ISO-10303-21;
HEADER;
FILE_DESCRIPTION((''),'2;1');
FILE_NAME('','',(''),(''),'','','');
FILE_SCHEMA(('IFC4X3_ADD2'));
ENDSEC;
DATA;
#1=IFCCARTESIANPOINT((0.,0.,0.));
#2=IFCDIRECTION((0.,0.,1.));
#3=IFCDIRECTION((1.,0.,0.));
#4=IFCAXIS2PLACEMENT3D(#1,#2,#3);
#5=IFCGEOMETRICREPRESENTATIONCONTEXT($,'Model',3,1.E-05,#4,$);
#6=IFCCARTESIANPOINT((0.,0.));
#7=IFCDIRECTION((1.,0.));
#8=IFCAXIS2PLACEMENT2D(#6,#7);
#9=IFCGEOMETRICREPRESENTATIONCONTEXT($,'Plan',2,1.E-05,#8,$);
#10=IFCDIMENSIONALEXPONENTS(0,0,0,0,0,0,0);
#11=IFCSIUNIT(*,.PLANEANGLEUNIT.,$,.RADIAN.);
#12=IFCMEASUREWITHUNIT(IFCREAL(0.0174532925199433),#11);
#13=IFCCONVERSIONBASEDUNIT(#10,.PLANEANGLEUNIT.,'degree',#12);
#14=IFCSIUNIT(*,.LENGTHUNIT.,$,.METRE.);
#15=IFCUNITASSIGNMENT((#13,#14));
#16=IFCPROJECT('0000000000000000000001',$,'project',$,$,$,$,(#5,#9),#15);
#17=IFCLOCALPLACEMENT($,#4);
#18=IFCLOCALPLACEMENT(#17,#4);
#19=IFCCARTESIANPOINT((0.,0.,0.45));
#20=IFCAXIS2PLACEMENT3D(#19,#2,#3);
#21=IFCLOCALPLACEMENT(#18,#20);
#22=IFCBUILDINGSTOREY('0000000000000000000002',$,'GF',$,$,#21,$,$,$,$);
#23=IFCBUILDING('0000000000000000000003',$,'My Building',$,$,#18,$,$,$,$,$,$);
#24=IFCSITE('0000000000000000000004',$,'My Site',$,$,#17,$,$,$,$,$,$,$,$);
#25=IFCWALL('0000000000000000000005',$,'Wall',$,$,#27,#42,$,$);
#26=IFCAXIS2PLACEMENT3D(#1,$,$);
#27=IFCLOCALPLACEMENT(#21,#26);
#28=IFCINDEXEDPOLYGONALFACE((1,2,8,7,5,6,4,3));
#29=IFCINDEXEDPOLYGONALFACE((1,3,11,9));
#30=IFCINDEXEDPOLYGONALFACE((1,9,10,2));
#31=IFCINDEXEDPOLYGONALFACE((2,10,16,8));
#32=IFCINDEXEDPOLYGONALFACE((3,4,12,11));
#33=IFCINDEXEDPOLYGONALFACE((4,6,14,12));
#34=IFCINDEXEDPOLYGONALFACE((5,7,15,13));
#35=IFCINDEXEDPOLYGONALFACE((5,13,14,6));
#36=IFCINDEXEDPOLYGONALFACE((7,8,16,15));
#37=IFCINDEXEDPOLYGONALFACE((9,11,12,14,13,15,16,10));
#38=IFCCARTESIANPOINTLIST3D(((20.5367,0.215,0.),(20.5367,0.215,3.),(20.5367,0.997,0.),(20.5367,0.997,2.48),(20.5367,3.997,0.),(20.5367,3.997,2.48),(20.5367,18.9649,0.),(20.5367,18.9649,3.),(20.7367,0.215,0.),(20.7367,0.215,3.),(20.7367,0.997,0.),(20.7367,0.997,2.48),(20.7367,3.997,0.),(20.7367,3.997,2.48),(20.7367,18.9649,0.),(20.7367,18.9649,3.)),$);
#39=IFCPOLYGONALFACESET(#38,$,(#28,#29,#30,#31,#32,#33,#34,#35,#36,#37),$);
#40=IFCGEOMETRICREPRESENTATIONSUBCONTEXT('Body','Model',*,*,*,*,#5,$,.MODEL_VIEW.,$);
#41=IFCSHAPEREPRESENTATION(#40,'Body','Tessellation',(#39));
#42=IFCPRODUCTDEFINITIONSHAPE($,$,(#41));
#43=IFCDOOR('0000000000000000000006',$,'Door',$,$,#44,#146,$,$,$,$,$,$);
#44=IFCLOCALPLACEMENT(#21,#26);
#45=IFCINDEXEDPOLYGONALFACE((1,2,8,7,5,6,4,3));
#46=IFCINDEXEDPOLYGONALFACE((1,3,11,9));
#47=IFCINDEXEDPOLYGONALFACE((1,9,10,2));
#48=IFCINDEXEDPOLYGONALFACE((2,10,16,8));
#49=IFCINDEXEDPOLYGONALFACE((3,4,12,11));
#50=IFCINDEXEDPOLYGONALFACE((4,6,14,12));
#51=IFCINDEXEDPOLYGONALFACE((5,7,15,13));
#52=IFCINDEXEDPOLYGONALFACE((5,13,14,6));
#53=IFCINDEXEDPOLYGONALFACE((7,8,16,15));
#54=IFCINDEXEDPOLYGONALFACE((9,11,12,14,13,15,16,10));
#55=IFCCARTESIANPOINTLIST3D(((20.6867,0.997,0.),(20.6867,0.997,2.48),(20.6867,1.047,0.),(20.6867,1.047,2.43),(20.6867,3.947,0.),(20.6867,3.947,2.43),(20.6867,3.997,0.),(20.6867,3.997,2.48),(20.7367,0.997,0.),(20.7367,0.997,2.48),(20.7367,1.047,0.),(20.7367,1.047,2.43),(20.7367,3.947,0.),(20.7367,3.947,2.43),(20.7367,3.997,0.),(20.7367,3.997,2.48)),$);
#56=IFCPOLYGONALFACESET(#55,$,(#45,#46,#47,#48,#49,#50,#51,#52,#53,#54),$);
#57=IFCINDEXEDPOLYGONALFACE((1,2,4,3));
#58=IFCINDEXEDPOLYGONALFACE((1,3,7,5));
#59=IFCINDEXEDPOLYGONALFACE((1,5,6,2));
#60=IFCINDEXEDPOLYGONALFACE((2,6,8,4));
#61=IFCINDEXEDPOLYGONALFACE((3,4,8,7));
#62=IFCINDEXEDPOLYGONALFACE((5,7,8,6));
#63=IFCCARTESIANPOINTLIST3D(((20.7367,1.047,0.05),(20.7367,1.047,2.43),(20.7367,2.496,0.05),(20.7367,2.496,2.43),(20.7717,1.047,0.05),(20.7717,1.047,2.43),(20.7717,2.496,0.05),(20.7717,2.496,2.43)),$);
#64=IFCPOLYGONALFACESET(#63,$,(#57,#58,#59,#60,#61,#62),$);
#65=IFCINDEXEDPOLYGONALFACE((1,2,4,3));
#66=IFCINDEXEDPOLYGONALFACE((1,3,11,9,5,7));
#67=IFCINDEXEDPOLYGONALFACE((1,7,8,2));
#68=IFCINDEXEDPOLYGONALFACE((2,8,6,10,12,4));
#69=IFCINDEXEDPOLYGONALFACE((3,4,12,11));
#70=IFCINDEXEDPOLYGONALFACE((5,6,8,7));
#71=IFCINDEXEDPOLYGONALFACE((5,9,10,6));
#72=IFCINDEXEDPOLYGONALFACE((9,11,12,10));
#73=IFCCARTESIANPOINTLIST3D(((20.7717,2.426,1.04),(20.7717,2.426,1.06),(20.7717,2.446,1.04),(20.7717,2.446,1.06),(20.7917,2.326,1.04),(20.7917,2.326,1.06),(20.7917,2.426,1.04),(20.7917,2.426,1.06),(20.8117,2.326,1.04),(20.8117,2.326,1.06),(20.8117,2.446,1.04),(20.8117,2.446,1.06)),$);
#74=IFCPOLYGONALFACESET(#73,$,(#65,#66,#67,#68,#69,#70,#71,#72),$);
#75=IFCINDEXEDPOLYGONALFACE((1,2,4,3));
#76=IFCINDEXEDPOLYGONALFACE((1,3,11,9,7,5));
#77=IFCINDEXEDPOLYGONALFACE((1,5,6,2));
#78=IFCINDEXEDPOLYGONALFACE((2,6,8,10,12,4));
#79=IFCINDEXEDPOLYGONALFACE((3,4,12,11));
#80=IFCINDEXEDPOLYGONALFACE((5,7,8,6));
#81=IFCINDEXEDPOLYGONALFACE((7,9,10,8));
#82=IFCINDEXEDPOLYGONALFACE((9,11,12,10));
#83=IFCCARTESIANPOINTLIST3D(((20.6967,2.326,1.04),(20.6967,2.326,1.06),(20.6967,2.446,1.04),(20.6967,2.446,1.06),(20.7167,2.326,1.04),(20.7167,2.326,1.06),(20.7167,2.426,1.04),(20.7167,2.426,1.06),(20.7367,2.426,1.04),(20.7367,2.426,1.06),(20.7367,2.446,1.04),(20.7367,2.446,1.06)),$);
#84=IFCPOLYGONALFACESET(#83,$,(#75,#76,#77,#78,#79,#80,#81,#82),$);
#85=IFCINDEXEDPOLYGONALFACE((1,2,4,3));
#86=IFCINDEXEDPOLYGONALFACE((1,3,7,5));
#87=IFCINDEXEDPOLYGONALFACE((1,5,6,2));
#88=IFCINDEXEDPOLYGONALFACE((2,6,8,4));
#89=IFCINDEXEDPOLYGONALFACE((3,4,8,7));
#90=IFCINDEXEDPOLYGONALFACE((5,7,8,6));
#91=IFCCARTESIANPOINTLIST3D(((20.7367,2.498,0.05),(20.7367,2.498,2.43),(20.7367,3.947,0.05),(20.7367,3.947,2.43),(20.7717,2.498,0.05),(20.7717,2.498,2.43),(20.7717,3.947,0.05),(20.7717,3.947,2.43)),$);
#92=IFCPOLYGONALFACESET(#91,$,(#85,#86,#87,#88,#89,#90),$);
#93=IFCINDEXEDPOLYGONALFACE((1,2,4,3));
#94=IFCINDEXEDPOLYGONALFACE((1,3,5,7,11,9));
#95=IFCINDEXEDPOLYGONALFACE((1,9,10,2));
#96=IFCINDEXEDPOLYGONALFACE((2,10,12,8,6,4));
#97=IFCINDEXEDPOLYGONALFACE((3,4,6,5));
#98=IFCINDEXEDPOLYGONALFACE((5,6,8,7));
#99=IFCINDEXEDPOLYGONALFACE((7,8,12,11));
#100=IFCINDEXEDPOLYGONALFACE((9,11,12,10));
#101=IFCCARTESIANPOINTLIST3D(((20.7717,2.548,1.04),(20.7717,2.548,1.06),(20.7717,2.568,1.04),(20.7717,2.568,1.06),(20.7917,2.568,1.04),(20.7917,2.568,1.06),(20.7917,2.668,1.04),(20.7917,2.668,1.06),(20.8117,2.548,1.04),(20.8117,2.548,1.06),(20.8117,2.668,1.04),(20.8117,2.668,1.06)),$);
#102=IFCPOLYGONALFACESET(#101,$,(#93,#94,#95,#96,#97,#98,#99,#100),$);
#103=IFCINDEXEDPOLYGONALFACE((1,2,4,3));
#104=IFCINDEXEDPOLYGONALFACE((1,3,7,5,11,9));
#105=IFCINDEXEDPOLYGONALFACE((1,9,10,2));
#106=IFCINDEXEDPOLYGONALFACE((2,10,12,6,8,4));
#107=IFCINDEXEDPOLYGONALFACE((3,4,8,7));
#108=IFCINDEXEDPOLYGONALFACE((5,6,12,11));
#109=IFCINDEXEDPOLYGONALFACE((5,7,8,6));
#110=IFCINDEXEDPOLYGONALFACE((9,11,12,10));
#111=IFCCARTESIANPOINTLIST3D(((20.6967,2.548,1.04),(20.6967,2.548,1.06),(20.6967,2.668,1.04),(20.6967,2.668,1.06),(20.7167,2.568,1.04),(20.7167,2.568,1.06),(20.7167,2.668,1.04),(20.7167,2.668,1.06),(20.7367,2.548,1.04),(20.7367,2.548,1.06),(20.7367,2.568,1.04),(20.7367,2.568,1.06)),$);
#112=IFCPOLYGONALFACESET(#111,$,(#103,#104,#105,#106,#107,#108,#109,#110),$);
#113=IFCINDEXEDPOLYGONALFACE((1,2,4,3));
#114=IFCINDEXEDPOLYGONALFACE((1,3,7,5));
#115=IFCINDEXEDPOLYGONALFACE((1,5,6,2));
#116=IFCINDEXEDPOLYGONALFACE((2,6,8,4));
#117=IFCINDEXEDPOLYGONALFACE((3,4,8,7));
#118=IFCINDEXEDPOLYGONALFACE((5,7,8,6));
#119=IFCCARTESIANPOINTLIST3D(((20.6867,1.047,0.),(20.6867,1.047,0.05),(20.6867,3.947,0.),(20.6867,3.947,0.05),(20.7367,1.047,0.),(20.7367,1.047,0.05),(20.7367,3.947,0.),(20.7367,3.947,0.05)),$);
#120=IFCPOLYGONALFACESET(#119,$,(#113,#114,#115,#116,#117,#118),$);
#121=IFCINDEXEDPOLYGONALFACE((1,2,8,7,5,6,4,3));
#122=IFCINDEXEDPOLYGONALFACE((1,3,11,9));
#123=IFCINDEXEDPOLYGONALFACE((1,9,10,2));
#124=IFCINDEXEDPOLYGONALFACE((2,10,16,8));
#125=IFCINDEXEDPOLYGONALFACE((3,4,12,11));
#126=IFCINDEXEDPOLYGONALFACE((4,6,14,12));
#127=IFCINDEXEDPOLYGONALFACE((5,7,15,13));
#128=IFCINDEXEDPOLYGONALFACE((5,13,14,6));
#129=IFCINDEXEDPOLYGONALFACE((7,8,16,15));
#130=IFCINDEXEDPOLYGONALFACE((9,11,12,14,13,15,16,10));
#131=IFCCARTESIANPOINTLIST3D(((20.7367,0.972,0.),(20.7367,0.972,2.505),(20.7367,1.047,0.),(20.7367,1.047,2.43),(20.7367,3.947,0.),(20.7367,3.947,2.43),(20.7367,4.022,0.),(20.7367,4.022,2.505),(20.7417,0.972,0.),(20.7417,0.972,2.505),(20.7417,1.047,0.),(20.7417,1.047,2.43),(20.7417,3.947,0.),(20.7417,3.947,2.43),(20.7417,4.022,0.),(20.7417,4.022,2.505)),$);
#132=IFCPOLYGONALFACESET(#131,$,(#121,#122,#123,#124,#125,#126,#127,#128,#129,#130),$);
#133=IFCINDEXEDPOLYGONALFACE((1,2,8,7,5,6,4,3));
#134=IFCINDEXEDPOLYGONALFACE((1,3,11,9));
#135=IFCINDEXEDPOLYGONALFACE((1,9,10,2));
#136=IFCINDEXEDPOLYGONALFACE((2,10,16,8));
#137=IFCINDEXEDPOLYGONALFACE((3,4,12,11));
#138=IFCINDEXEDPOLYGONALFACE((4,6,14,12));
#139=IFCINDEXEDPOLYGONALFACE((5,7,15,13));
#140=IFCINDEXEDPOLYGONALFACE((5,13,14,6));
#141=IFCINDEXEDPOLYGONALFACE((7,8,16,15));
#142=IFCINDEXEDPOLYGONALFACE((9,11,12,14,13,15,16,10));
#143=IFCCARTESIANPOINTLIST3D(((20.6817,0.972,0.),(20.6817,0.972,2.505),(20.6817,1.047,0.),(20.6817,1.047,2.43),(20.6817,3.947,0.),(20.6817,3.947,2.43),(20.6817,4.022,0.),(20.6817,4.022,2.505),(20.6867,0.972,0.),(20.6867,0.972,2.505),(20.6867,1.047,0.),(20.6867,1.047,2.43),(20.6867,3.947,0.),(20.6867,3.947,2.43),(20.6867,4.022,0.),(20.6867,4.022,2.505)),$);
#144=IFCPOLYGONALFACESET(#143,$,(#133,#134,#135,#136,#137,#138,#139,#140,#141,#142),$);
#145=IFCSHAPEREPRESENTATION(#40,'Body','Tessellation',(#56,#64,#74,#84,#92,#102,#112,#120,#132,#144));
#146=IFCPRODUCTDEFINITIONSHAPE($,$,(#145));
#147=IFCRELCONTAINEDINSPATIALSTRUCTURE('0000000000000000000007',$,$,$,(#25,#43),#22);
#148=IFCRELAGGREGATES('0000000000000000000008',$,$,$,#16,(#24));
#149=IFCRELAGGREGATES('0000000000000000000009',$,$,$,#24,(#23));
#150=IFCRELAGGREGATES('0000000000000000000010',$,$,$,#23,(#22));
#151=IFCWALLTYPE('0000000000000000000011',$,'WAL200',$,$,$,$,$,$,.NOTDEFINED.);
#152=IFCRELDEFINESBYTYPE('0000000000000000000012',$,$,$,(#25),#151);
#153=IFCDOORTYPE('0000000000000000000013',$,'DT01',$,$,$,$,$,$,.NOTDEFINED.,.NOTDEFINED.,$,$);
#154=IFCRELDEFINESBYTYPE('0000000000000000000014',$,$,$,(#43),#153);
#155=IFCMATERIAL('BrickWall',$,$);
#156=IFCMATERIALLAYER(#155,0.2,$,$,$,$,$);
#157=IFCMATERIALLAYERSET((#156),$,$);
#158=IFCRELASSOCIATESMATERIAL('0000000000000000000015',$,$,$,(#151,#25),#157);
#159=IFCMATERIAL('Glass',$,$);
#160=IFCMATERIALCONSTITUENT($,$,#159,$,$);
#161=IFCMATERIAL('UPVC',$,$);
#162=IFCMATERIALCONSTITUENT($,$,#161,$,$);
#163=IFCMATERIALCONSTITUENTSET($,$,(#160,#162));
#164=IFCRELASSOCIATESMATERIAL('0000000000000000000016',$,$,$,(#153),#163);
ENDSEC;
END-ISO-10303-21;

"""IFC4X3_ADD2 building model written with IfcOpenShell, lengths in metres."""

from ifc_helpers import new_model, entity, si_unit, converted_unit, frame, origin_with_axes, origin_2d_with_axis, place, context, subcontext, project, spatial, line, indexed_curve, outline, extrude, shape, source, transform, mapped, material, layer, layer_set, layer_usage, constituent, constituent_set, type_object, type_shapes, element, fill, save


model = new_model("IFC4X3_ADD2")

# Units and contexts
model_context = context("Model", 3, precision=1e-05, world=origin_with_axes())
plan_context = context("Plan", 2, precision=1e-05, world=origin_2d_with_axis())
body_context_1 = subcontext(model_context, "Body", "Model", "MODEL_VIEW")
body_context_2 = subcontext(plan_context, "Body", "Plan", "PLAN_VIEW")
ifc_project = project(units=[converted_unit("PLANEANGLEUNIT", "degree", entity("IfcReal", 0.0174532925199433), si_unit("PLANEANGLEUNIT", "RADIAN"), dimensions=[0, 0, 0, 0, 0, 0, 0]), si_unit("LENGTHUNIT", "METRE")], contexts=[model_context, plan_context])

# Site, building, storey
site_placement = place(None, origin_with_axes())
site = spatial("IfcSite", under=ifc_project, at=site_placement, Name="My Site")
building_placement = place(site_placement, origin_with_axes())
building = spatial("IfcBuilding", under=site, at=building_placement, Name="My Building")
storey_placement = place(building_placement, frame((0.0, 0.0, 0.45), z_axis=(0.0, 0.0, 1.0), x_axis=(1.0, 0.0, 0.0)))
storey = spatial("IfcBuildingStorey", under=building, at=storey_placement, Name="GF")

# Shared definitions
ifc_material_1 = material(Name="BrickWall")
ifc_layer_1 = layer(ifc_material_1, 0.2)
ifc_layer_set_1 = layer_set([ifc_layer_1])
wall_type_1 = type_object("IfcWallType", Name="WAL200", PredefinedType="NOTDEFINED", material=ifc_layer_set_1)
shared_shape_1 = source(origin_with_axes(), body_context_1, "Body", "SweptSolid", [
    extrude(outline(indexed_curve([(0.0, 0.0), (3.0, 0.0), (3.0, 2.48), (0.0, 2.48)], segments=[line(1, 2, 3, 4, 1)])), frame((0.0, -0.6, 0.0), z_axis=(0.0, -1.0, 0.0), x_axis=(1.0, 0.0, 0.0)), (0.0, 0.0, -1.0), 1.2),
])
ifc_material_2 = material(Name="Glass")
ifc_constituent_1 = constituent(ifc_material_2)
ifc_material_3 = material(Name="UPVC")
ifc_constituent_2 = constituent(ifc_material_3)
ifc_constituent_set = constituent_set(constituents=[ifc_constituent_1, ifc_constituent_2])
door_type_1 = type_object("IfcDoorType", Name="DT01", OperationType="NOTDEFINED", PredefinedType="NOTDEFINED", material=ifc_constituent_set)
shared_shape_2 = source(origin_with_axes(), body_context_1, "Body", "SweptSolid", [
    extrude(outline(indexed_curve([(3.0, 0.0), (3.0, 2.48), (0.0, 2.48), (0.0, 0.0), (0.05, 0.0), (0.05, 2.43), (2.95, 2.43), (2.95, 0.0)], segments=[line(5, 4), line(4, 3), line(3, 2), line(2, 1), line(1, 8), line(8, 7), line(7, 6), line(6, 5)], self_intersect=False)), frame((0.0, 0.0, 0.0), z_axis=(0.0, -1.0, 0.0), x_axis=(1.0, 0.0, 0.0)), (0.0, 0.0, -1.0), 0.05),
    extrude(outline(indexed_curve([(0.0, 0.0), (1.449, 0.0), (1.449, 0.035), (0.0, 0.035)], segments=[line(1, 2, 3, 4, 1)])), frame((0.05, -0.035, 0.05), z_axis=(0.0, 0.0, 1.0), x_axis=(1.0, 0.0, 0.0)), (0.0, 0.0, 1.0), 2.38),
    extrude(outline(indexed_curve([(0.0, 0.0), (0.0, -0.04), (-0.12, -0.04), (-0.12, -0.02), (-0.02, -0.02), (-0.02, 0.0)], segments=[line(1, 2, 3, 4, 5, 6, 1)])), frame((1.449, -0.035, 1.04), z_axis=(0.0, 0.0, 1.0), x_axis=(1.0, 0.0, 0.0)), (0.0, 0.0, 1.0), 0.02),
    extrude(outline(indexed_curve([(0.0, 0.0), (0.0, 0.04), (-0.12, 0.04), (-0.12, 0.02), (-0.02, 0.02), (-0.02, 0.0)], segments=[line(1, 2, 3, 4, 5, 6, 1)])), frame((1.449, 0.0, 1.04), z_axis=(0.0, 0.0, 1.0), x_axis=(1.0, 0.0, 0.0)), (0.0, 0.0, 1.0), 0.02),
    extrude(outline(indexed_curve([(0.0, 0.0), (-1.449, 0.0), (-1.449, 0.035), (0.0, 0.035)], segments=[line(1, 2, 3, 4, 1)])), frame((2.95, -0.035, 0.05), z_axis=(0.0, 0.0, 1.0), x_axis=(1.0, 0.0, 0.0)), (0.0, 0.0, 1.0), 2.38),
    extrude(outline(indexed_curve([(0.0, 0.0), (0.0, -0.04), (0.12, -0.04), (0.12, -0.02), (0.02, -0.02), (0.02, 0.0)], segments=[line(1, 2, 3, 4, 5, 6, 1)])), frame((1.551, -0.035, 1.04), z_axis=(0.0, 0.0, 1.0), x_axis=(1.0, 0.0, 0.0)), (0.0, 0.0, 1.0), 0.02),
    extrude(outline(indexed_curve([(0.0, 0.0), (0.0, 0.04), (0.12, 0.04), (0.12, 0.02), (0.02, 0.02), (0.02, 0.0)], segments=[line(1, 2, 3, 4, 5, 6, 1)])), frame((1.551, 0.0, 1.04), z_axis=(0.0, 0.0, 1.0), x_axis=(1.0, 0.0, 0.0)), (0.0, 0.0, 1.0), 0.02),
    extrude(outline(indexed_curve([(0.0, 0.0), (2.9, 0.0), (2.9, 0.05), (0.0, 0.05)], segments=[line(1, 2, 3, 4, 1)])), frame((0.05, 0.0, 0.0), z_axis=(0.0, 0.0, 1.0), x_axis=(1.0, 0.0, 0.0)), (0.0, 0.0, 1.0), 0.05),
    extrude(outline(indexed_curve([(0.0, 0.0), (0.0, 2.505), (3.05, 2.505), (3.05, 0.0), (2.975, 0.0), (2.975, 2.43), (0.075, 2.43), (0.075, 0.0)], segments=[line(1, 2, 3, 4, 5, 6, 7, 8, 1)])), frame((-0.025, -0.005, 0.0), z_axis=(0.0, -1.0, 0.0), x_axis=(1.0, 0.0, 0.0)), (0.0, 0.0, -1.0), 0.005),
    extrude(outline(indexed_curve([(0.0, 0.0), (0.0, 2.505), (3.05, 2.505), (3.05, 0.0), (2.975, 0.0), (2.975, 2.43), (0.075, 2.43), (0.075, 0.0)], segments=[line(1, 2, 3, 4, 5, 6, 7, 8, 1)])), frame((-0.025, 0.05, 0.0), z_axis=(0.0, -1.0, 0.0), x_axis=(1.0, 0.0, 0.0)), (0.0, 0.0, -1.0), 0.005),
])
shared_shape_3 = source(origin_with_axes(), body_context_2, "Body", "Curve2D", [
    entity("IfcIndexedPolyCurve", entity("IfcCartesianPointList2D", [[0.0, 0.0], [0.05, 0.0], [0.05, 0.05], [0.0, 0.05]]), [entity("IfcLineIndex", [1, 2, 3, 4, 1])]),
    entity("IfcIndexedPolyCurve", entity("IfcCartesianPointList2D", [[3.0, 0.0], [2.95, 0.0], [2.95, 0.05], [3.0, 0.05]]), [entity("IfcLineIndex", [1, 2, 3, 4, 1])]),
    entity("IfcIndexedPolyCurve", entity("IfcCartesianPointList2D", [[-0.675, -0.035], [0.775, -0.035], [0.775, 0.0], [-0.675, 0.0]]), [entity("IfcLineIndex", [1, 2, 3, 4, 1])]),
    entity("IfcIndexedPolyCurve", entity("IfcCartesianPointList2D", [[3.675, -0.035], [2.225, -0.035], [2.225, 0.0], [3.675, 0.0]]), [entity("IfcLineIndex", [1, 2, 3, 4, 1])]),
])
type_shapes(door_type_1, [shared_shape_2, shared_shape_3])

# Wall, opening, door
ifc_layer_usage_1 = layer_usage(ifc_layer_set_1, "AXIS2", "POSITIVE", 0.0)
wall_1_placement = place(storey_placement, frame((20.7367, 0.215, 0.0), z_axis=(0.0, 0.0, 1.0), x_axis=(0.0, 1.0, 0.0)))
wall_1 = element("IfcWall", 1, at=wall_1_placement, inside=storey, type_object=wall_type_1, material=ifc_layer_usage_1, Name="Wall", context=body_context_1, shape_type="SweptSolid", body=[
    extrude(outline(indexed_curve([(0.0, 0.0), (0.0, 0.2), (18.7499, 0.2), (18.7499, 0.0), (0.0, 0.0)], self_intersect=False)), origin_with_axes(), (0.0, 0.0, 1.0), 3.0),
])
opening_1_placement = place(wall_1_placement, frame((0.782, 0.0, 0.0), z_axis=(0.0, 0.0, 1.0), x_axis=(1.0, 0.0, 0.0)))
opening_1 = element("IfcOpeningElement", 2, at=opening_1_placement, cuts=wall_1, PredefinedType="OPENING", context=body_context_1, shape_type="MappedRepresentation", body=[
    mapped(shared_shape_1, transform((0.0, 0.0, 0.0), x_axis=(1.0, 0.0, 0.0), y_axis=(0.0, 1.0, 0.0), z_axis=(0.0, 0.0, 1.0), scale=1.0)),
])
door_1_placement = place(opening_1_placement, frame((0.0, 0.0, 0.0), z_axis=(0.0, 0.0, 1.0), x_axis=(1.0, 0.0, 0.0)))
door_1 = element("IfcDoor", 3, at=door_1_placement, inside=storey, type_object=door_type_1, Name="Door", shapes=[
    shape(body_context_1, "Body", "MappedRepresentation", [mapped(shared_shape_2, transform((0.0, 0.0, 0.0), x_axis=(1.0, 0.0, 0.0), y_axis=(0.0, 1.0, 0.0), z_axis=(0.0, 0.0, 1.0), scale=1.0))]),
    shape(body_context_2, "Body", "MappedRepresentation", [mapped(shared_shape_3, transform((0.0, 0.0, 0.0), x_axis=(1.0, 0.0, 0.0), y_axis=(0.0, 1.0, 0.0), z_axis=(0.0, 0.0, 1.0), scale=1.0))]),
])
fill(opening_1, door_1)

save(model, "model.ifc")
